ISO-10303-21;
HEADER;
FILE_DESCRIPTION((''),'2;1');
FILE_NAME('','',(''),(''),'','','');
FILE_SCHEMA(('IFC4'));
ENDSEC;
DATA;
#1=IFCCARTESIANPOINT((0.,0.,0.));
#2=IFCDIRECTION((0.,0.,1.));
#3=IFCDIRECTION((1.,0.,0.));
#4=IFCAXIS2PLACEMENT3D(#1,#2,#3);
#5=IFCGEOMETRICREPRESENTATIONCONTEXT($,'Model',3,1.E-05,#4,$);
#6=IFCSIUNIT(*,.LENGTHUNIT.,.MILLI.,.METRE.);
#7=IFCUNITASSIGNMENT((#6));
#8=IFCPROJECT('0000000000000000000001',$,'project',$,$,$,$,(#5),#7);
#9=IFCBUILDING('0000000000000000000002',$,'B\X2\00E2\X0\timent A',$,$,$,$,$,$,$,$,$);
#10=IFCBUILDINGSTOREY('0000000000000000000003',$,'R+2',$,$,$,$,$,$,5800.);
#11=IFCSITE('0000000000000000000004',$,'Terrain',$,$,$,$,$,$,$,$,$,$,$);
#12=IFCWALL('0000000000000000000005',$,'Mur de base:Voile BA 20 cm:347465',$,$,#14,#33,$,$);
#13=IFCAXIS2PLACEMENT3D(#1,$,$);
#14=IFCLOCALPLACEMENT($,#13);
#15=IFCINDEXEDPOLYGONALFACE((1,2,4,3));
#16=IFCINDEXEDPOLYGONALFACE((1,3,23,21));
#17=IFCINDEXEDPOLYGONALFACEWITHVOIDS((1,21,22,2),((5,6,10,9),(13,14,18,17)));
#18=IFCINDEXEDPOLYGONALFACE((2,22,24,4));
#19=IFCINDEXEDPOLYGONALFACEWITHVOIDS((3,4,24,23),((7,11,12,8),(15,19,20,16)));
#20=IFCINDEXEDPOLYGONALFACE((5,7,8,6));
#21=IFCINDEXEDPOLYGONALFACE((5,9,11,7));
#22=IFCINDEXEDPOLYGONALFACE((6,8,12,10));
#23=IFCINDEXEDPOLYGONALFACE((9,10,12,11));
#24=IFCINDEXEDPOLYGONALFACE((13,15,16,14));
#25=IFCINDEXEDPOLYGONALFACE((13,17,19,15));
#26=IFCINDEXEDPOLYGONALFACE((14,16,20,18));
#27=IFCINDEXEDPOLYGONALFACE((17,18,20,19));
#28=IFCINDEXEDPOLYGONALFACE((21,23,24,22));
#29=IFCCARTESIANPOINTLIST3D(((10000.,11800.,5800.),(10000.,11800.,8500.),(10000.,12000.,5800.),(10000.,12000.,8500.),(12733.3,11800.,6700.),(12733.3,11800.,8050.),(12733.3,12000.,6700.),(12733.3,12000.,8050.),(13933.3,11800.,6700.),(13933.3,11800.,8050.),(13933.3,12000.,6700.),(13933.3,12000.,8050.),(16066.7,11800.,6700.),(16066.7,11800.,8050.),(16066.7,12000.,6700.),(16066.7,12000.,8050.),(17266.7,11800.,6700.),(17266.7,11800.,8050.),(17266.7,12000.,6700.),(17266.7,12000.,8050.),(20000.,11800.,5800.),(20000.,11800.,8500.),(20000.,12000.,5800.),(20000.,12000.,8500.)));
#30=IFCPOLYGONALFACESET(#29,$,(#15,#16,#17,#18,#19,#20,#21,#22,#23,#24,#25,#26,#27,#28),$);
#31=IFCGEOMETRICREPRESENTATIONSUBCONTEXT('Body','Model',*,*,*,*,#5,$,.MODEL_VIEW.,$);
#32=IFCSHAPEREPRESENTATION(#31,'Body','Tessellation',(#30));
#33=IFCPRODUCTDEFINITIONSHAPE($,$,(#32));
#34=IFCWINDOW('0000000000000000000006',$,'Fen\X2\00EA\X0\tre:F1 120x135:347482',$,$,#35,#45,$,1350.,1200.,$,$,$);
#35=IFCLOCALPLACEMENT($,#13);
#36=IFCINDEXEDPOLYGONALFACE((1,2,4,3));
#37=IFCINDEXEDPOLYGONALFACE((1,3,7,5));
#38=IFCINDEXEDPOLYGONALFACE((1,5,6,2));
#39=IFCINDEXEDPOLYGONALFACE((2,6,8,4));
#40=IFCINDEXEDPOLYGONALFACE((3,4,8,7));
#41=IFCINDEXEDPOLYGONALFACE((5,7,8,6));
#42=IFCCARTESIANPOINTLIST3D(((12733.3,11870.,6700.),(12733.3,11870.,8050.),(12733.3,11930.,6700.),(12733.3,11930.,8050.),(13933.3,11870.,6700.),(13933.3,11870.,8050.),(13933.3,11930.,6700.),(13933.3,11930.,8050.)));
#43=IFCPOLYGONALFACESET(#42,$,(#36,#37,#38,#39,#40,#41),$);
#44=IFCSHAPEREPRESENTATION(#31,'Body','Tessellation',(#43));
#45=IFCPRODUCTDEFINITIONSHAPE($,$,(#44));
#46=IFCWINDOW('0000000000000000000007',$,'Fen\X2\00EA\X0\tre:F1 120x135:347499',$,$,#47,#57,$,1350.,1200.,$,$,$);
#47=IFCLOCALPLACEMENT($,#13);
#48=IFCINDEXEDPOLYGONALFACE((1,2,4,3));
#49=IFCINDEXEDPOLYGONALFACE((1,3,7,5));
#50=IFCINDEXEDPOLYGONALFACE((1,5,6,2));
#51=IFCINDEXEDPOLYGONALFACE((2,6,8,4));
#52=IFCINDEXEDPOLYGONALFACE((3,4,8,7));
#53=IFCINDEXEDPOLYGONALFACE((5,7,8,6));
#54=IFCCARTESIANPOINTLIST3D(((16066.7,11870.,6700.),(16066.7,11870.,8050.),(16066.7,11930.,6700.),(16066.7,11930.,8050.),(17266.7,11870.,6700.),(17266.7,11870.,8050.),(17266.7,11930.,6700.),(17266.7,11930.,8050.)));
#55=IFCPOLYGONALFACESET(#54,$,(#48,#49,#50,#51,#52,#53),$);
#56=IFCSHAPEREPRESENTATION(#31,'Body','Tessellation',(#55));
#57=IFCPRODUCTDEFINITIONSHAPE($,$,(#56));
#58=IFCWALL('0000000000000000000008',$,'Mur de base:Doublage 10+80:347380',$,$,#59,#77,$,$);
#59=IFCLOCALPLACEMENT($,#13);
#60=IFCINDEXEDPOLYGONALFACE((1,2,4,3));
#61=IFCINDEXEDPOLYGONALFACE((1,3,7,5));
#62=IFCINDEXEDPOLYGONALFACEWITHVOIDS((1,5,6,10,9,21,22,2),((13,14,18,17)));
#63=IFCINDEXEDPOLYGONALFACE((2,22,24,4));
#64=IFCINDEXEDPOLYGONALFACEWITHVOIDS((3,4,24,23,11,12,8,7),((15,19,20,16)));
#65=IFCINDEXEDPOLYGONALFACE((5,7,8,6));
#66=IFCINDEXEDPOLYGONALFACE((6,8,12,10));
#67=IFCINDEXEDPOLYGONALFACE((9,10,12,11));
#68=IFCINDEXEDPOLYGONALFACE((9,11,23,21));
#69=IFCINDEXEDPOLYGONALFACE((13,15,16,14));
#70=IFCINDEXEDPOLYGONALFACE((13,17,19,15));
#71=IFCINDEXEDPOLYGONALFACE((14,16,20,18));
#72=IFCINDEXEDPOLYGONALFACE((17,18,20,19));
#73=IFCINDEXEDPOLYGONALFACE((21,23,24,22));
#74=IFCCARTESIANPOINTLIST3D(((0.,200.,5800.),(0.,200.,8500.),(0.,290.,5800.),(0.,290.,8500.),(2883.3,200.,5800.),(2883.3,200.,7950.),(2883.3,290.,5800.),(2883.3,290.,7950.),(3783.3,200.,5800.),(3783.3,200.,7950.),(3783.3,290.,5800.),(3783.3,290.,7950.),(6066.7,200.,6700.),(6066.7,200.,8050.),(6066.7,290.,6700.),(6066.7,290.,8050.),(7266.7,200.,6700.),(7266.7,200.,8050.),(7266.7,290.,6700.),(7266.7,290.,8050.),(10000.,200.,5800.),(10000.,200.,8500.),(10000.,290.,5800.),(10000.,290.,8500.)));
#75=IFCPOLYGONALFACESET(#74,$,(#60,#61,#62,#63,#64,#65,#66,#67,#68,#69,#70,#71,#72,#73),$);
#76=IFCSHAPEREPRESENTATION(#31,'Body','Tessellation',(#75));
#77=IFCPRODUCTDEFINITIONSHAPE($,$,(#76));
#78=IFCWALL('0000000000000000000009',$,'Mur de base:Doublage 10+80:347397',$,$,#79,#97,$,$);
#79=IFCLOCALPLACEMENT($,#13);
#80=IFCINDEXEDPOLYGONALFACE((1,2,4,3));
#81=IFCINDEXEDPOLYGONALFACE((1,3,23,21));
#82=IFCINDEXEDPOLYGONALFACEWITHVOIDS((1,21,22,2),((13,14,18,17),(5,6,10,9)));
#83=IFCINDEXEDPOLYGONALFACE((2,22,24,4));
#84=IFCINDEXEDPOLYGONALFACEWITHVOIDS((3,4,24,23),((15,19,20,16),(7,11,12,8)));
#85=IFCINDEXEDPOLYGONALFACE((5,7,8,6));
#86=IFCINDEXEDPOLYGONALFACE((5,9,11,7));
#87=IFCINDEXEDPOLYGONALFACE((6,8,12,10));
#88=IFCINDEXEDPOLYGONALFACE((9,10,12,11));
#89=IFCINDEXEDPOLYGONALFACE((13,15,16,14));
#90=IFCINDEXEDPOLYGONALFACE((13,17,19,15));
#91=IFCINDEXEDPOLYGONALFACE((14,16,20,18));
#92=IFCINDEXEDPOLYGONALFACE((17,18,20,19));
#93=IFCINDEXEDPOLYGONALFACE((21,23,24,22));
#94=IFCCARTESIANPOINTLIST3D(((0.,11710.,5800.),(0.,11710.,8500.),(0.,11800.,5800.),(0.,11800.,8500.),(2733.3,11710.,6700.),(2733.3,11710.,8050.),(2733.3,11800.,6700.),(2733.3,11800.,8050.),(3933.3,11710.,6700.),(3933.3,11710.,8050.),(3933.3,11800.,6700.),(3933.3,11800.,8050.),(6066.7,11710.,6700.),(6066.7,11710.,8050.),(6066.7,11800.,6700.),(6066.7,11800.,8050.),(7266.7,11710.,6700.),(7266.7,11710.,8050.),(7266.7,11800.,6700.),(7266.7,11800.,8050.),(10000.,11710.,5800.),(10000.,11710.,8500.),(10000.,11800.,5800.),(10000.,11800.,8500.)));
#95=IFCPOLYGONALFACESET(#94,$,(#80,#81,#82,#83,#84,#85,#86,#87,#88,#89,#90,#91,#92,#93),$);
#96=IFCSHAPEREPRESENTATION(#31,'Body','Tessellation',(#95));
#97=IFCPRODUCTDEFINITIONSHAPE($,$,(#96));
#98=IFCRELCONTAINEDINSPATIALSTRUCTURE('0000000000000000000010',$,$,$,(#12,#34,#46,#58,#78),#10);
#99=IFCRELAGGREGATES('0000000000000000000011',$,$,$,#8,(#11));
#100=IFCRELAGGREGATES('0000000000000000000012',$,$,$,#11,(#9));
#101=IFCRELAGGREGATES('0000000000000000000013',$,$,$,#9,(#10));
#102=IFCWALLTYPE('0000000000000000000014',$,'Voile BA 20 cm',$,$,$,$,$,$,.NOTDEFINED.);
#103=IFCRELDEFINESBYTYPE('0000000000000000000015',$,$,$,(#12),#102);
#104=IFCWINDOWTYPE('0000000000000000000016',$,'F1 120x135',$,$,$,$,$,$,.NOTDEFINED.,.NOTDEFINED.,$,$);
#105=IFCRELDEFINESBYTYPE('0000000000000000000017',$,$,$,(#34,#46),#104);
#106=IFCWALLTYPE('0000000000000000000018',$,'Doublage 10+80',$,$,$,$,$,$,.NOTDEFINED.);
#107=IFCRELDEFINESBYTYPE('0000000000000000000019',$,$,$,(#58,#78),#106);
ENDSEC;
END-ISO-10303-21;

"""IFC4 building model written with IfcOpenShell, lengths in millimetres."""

from ifc_helpers import new_model, si_unit, frame, frame_2d, origin_with_axes, place, context, subcontext, project, spatial, rectangle, extrude, type_object, element, fill, save


model = new_model("IFC4")

# Units and contexts
model_context = context("Model", 3, precision=1e-05, world=origin_with_axes())
body_context = subcontext(model_context, "Body", "Model", "MODEL_VIEW")
ifc_project = project(units=[si_unit("LENGTHUNIT", "METRE", prefix="MILLI")], contexts=[model_context])

# Site, building, storey
site = spatial("IfcSite", under=ifc_project, Name="Terrain")
building = spatial("IfcBuilding", under=site, Name="Bâtiment A")
storey = spatial("IfcBuildingStorey", under=building, Name="R+2", Elevation=5800.0)

# Shared definitions
wall_type_1 = type_object("IfcWallType", Name="Voile BA 20 cm", PredefinedType="NOTDEFINED")
window_type = type_object("IfcWindowType", Name="F1 120x135", PartitioningType="NOTDEFINED", PredefinedType="NOTDEFINED")

# Wall, openings, windows
wall_1_placement = place(None, origin_with_axes())
wall_1 = element("IfcWall", 1, at=wall_1_placement, inside=storey, type_object=wall_type_1, Name="Mur de base:Voile BA 20 cm:347465", context=body_context, shape_type="SweptSolid", body=[
    extrude(rectangle(XDim=10000.0, YDim=200.0, at=frame_2d((15000.0, 11900.0))), frame((0.0, 0.0, 5800.0), z_axis=(0.0, 0.0, 1.0), x_axis=(1.0, 0.0, 0.0)), (0.0, 0.0, 1.0), 2700.0),
])
opening_1_placement = place(None, origin_with_axes())
opening_1 = element("IfcOpeningElement", 2, at=opening_1_placement, cuts=wall_1, context=body_context, shape_type="SweptSolid", body=[
    extrude(rectangle(XDim=1200.0, YDim=320.0, at=frame_2d((13333.3, 11900.0))), frame((0.0, 0.0, 6700.0), z_axis=(0.0, 0.0, 1.0), x_axis=(1.0, 0.0, 0.0)), (0.0, 0.0, 1.0), 1350.0),
])
opening_2_placement = place(None, origin_with_axes())
opening_2 = element("IfcOpeningElement", 3, at=opening_2_placement, cuts=wall_1, context=body_context, shape_type="SweptSolid", body=[
    extrude(rectangle(XDim=1200.0, YDim=320.0, at=frame_2d((16666.7, 11900.0))), frame((0.0, 0.0, 6700.0), z_axis=(0.0, 0.0, 1.0), x_axis=(1.0, 0.0, 0.0)), (0.0, 0.0, 1.0), 1350.0),
])
window_1_placement = place(None, origin_with_axes())
window_1 = element("IfcWindow", 4, at=window_1_placement, inside=storey, type_object=window_type, Name="Fenêtre:F1 120x135:347482", OverallHeight=1350.0, OverallWidth=1200.0, context=body_context, shape_type="SweptSolid", body=[
    extrude(rectangle(XDim=1200.0, YDim=60.0, at=frame_2d((13333.3, 11900.0))), frame((0.0, 0.0, 6700.0), z_axis=(0.0, 0.0, 1.0), x_axis=(1.0, 0.0, 0.0)), (0.0, 0.0, 1.0), 1350.0),
])
fill(opening_1, window_1)
window_2_placement = place(None, origin_with_axes())
window_2 = element("IfcWindow", 5, at=window_2_placement, inside=storey, type_object=window_type, Name="Fenêtre:F1 120x135:347499", OverallHeight=1350.0, OverallWidth=1200.0, context=body_context, shape_type="SweptSolid", body=[
    extrude(rectangle(XDim=1200.0, YDim=60.0, at=frame_2d((16666.7, 11900.0))), frame((0.0, 0.0, 6700.0), z_axis=(0.0, 0.0, 1.0), x_axis=(1.0, 0.0, 0.0)), (0.0, 0.0, 1.0), 1350.0),
])
fill(opening_2, window_2)

# Walls, openings
wall_type_2 = type_object("IfcWallType", Name="Doublage 10+80", PredefinedType="NOTDEFINED")
wall_2_placement = place(None, origin_with_axes())
wall_2 = element("IfcWall", 6, at=wall_2_placement, inside=storey, type_object=wall_type_2, Name="Mur de base:Doublage 10+80:347380", context=body_context, shape_type="SweptSolid", body=[
    extrude(rectangle(XDim=10000.0, YDim=90.0, at=frame_2d((5000.0, 245.0))), frame((0.0, 0.0, 5800.0), z_axis=(0.0, 0.0, 1.0), x_axis=(1.0, 0.0, 0.0)), (0.0, 0.0, 1.0), 2700.0),
])
opening_3_placement = place(None, origin_with_axes())
element("IfcOpeningElement", 7, at=opening_3_placement, cuts=wall_2, context=body_context, shape_type="SweptSolid", body=[
    extrude(rectangle(XDim=900.0, YDim=210.0, at=frame_2d((3333.3, 245.0))), frame((0.0, 0.0, 5800.0), z_axis=(0.0, 0.0, 1.0), x_axis=(1.0, 0.0, 0.0)), (0.0, 0.0, 1.0), 2150.0),
])
opening_4_placement = place(None, origin_with_axes())
element("IfcOpeningElement", 8, at=opening_4_placement, cuts=wall_2, context=body_context, shape_type="SweptSolid", body=[
    extrude(rectangle(XDim=1200.0, YDim=210.0, at=frame_2d((6666.7, 245.0))), frame((0.0, 0.0, 6700.0), z_axis=(0.0, 0.0, 1.0), x_axis=(1.0, 0.0, 0.0)), (0.0, 0.0, 1.0), 1350.0),
])
wall_3_placement = place(None, origin_with_axes())
wall_3 = element("IfcWall", 9, at=wall_3_placement, inside=storey, type_object=wall_type_2, Name="Mur de base:Doublage 10+80:347397", context=body_context, shape_type="SweptSolid", body=[
    extrude(rectangle(XDim=10000.0, YDim=90.0, at=frame_2d((5000.0, 11755.0))), frame((0.0, 0.0, 5800.0), z_axis=(0.0, 0.0, 1.0), x_axis=(1.0, 0.0, 0.0)), (0.0, 0.0, 1.0), 2700.0),
])
opening_5_placement = place(None, origin_with_axes())
element("IfcOpeningElement", 10, at=opening_5_placement, cuts=wall_3, context=body_context, shape_type="SweptSolid", body=[
    extrude(rectangle(XDim=1200.0, YDim=210.0, at=frame_2d((3333.3, 11755.0))), frame((0.0, 0.0, 6700.0), z_axis=(0.0, 0.0, 1.0), x_axis=(1.0, 0.0, 0.0)), (0.0, 0.0, 1.0), 1350.0),
])
opening_6_placement = place(None, origin_with_axes())
element("IfcOpeningElement", 11, at=opening_6_placement, cuts=wall_3, context=body_context, shape_type="SweptSolid", body=[
    extrude(rectangle(XDim=1200.0, YDim=210.0, at=frame_2d((6666.7, 11755.0))), frame((0.0, 0.0, 6700.0), z_axis=(0.0, 0.0, 1.0), x_axis=(1.0, 0.0, 0.0)), (0.0, 0.0, 1.0), 1350.0),
])

save(model, "model.ifc")
